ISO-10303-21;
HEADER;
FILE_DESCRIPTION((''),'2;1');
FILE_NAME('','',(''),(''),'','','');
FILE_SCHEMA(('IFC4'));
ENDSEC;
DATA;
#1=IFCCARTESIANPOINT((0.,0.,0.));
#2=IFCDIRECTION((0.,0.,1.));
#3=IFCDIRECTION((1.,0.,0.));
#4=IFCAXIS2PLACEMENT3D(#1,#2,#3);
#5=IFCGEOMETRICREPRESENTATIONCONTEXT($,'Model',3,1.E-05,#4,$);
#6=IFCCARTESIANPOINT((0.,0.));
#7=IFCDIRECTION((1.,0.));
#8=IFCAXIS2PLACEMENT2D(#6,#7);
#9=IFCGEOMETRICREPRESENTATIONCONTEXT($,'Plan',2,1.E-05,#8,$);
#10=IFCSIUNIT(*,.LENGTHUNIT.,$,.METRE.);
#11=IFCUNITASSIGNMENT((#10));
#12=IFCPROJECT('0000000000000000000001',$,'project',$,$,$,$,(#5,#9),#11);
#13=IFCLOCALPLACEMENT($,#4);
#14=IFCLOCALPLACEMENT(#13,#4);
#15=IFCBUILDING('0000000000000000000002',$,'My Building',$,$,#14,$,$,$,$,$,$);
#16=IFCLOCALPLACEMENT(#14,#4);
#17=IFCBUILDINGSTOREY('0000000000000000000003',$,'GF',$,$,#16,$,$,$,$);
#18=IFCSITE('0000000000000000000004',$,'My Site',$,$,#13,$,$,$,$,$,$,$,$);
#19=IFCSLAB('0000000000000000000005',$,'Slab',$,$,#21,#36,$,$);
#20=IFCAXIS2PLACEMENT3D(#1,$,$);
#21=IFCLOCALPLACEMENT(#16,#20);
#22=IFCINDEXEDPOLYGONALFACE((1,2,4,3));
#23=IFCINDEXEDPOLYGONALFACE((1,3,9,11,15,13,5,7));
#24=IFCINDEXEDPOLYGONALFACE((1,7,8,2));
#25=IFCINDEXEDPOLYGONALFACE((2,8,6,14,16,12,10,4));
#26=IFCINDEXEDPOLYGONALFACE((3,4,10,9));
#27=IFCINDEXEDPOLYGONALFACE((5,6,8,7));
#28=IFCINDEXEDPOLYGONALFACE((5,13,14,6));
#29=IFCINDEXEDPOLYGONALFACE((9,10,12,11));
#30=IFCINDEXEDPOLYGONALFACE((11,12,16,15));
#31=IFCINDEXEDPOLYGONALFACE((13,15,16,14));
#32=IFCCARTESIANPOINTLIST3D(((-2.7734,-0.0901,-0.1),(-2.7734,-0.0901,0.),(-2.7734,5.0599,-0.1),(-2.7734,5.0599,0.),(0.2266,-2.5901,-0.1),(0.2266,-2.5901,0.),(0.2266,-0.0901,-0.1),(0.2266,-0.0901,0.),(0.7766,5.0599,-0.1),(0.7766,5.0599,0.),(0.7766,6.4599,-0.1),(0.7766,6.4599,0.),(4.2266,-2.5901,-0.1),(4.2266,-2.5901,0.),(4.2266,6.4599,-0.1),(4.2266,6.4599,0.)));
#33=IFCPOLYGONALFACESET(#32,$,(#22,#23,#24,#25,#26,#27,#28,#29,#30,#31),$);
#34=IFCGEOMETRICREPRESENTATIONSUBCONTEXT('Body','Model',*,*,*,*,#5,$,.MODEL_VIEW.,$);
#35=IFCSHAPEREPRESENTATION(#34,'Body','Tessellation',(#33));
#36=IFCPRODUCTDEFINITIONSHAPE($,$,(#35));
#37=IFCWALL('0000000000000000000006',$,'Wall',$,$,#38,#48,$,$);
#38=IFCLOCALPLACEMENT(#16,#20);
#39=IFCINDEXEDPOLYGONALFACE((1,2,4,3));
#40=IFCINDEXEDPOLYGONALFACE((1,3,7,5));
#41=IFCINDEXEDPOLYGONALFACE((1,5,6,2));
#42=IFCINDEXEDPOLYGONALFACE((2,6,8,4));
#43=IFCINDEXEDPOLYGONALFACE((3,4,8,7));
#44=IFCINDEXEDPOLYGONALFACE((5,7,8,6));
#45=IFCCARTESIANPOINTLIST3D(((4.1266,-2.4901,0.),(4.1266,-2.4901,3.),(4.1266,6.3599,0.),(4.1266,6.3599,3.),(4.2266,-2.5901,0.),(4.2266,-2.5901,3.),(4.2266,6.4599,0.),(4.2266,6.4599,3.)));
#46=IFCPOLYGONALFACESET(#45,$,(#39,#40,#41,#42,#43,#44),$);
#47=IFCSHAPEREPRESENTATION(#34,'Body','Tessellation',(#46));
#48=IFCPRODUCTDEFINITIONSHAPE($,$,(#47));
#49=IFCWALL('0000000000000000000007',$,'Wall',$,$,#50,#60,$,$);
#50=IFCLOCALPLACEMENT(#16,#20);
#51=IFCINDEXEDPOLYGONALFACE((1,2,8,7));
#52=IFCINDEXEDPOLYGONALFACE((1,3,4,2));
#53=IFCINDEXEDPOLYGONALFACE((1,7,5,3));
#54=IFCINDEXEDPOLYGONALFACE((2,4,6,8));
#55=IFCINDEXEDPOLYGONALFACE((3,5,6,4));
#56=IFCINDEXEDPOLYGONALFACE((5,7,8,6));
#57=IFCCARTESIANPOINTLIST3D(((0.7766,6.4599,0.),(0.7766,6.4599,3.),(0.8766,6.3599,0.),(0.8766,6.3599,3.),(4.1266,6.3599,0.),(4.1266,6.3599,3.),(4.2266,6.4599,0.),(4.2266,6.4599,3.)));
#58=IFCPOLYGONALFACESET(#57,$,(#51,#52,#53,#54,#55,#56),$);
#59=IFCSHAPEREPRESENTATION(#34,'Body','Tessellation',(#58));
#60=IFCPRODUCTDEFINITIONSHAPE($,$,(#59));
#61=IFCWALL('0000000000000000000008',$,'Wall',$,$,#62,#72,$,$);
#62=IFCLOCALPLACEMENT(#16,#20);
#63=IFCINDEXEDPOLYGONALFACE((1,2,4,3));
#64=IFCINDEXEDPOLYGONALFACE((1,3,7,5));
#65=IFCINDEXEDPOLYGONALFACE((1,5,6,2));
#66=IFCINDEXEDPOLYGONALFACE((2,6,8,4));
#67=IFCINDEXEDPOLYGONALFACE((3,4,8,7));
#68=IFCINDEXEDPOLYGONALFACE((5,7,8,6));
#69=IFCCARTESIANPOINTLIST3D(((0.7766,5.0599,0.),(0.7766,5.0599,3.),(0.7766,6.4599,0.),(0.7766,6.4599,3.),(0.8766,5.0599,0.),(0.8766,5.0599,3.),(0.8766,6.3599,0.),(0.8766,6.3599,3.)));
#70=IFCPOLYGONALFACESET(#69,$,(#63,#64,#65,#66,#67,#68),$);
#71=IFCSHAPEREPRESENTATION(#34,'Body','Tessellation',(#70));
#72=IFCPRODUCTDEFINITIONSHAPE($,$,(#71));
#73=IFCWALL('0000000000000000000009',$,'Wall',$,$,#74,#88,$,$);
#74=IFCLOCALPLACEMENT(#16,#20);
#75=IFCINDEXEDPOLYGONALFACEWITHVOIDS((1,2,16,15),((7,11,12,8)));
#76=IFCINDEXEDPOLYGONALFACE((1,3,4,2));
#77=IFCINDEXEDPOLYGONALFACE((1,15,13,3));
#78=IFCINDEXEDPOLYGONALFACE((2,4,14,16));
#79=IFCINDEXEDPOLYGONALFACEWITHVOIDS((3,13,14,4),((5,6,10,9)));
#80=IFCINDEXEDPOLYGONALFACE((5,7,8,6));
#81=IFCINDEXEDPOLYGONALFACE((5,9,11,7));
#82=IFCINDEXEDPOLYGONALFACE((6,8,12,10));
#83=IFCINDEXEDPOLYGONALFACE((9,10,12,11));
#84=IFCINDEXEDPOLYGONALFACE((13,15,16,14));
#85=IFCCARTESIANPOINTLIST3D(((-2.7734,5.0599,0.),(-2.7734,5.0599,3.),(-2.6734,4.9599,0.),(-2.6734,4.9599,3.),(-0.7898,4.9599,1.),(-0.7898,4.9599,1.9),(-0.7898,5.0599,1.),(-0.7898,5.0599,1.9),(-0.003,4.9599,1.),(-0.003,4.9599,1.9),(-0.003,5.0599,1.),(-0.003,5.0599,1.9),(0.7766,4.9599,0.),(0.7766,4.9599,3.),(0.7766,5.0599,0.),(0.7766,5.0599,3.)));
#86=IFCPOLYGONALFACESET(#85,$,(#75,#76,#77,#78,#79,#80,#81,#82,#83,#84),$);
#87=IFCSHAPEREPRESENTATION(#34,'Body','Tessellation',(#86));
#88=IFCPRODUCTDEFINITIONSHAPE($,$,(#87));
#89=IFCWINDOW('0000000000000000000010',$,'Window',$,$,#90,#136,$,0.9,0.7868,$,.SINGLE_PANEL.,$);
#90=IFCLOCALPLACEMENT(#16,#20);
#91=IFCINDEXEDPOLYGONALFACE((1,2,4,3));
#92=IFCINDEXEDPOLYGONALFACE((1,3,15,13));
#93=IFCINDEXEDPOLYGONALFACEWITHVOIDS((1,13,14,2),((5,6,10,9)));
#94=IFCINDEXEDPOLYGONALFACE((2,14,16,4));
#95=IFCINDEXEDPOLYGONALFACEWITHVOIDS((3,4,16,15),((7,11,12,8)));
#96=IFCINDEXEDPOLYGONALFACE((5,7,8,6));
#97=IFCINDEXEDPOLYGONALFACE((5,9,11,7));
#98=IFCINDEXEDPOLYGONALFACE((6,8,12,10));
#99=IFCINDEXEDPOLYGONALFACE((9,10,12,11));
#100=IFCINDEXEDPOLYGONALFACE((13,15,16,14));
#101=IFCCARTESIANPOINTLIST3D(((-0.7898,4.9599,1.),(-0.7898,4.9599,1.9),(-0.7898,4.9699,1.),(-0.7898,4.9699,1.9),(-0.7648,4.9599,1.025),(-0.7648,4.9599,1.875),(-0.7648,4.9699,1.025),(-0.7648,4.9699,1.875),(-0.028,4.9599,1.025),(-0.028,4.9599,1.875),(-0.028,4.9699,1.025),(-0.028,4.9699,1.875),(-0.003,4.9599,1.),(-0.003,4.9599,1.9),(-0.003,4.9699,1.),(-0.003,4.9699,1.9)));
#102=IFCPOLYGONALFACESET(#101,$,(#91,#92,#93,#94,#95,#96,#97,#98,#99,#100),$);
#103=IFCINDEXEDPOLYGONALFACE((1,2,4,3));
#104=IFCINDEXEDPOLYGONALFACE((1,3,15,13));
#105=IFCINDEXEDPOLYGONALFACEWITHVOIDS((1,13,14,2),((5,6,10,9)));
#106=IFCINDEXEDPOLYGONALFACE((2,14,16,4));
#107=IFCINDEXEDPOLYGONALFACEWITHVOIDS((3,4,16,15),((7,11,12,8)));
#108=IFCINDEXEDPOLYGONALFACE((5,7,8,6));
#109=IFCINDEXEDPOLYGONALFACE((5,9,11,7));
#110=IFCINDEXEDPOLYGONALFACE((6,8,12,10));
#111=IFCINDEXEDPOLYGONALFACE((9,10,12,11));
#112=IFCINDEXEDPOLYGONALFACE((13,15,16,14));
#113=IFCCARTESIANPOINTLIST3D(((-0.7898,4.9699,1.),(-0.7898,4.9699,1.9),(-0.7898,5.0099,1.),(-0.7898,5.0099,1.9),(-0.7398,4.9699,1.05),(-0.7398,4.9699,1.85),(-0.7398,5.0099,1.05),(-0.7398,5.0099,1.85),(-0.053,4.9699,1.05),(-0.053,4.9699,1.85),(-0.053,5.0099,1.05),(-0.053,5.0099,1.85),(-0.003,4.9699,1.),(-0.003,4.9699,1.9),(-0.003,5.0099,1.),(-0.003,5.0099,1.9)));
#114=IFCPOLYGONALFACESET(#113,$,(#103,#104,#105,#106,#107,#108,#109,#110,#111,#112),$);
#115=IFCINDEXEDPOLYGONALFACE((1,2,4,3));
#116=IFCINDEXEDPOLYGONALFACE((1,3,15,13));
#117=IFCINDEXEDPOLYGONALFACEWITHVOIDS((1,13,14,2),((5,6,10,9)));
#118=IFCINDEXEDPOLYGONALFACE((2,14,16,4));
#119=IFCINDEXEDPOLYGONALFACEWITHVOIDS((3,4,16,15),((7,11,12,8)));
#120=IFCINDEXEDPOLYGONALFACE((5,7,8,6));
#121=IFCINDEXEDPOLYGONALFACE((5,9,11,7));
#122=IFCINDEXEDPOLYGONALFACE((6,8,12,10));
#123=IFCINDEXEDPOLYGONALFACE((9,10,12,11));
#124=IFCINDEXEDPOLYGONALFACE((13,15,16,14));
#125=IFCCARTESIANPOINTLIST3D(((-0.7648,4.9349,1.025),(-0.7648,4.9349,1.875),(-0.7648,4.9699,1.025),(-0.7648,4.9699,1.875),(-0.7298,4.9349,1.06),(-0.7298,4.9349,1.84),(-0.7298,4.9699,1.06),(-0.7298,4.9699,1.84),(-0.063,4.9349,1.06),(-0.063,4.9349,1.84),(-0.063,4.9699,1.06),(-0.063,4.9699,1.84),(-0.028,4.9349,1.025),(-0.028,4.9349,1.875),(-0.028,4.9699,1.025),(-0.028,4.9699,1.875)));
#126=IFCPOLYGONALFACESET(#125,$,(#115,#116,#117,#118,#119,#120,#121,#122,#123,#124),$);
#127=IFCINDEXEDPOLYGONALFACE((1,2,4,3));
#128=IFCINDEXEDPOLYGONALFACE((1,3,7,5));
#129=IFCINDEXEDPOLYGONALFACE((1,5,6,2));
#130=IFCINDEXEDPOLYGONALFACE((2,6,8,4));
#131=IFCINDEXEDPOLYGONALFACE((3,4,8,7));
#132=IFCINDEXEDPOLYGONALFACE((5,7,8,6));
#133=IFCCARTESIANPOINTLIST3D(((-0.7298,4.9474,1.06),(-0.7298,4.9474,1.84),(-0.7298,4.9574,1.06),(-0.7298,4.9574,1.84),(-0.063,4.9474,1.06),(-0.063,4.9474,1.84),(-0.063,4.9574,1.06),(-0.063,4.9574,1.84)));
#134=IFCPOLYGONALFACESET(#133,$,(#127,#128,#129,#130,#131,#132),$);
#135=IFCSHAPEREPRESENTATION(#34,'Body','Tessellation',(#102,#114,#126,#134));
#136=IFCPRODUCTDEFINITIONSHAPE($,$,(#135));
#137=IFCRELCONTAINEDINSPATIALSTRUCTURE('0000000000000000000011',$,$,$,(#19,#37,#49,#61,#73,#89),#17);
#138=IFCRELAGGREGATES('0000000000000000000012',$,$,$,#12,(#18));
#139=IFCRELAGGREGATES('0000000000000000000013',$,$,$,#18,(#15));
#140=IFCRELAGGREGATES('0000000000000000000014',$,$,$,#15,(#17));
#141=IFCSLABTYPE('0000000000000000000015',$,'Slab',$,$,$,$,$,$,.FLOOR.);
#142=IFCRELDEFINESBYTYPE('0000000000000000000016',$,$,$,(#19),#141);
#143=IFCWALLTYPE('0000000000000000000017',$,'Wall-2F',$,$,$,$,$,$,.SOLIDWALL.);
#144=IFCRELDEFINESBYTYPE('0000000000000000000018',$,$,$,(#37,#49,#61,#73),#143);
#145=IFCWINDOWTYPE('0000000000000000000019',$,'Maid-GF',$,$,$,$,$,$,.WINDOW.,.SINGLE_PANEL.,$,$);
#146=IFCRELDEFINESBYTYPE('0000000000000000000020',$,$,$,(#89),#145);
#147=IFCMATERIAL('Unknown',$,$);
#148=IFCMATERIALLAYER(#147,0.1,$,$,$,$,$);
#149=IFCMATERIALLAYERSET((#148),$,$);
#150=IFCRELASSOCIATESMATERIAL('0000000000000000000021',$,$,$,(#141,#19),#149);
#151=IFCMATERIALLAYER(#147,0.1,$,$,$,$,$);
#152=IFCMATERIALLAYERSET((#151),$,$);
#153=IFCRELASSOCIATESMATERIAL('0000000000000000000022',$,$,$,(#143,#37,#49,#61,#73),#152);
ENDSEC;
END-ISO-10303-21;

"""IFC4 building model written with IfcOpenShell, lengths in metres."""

from ifc_helpers import new_model, entity, si_unit, frame, origin_with_axes, origin_2d_with_axis, place, context, subcontext, project, spatial, line, indexed_curve, outline, extrude, shape, source, transform, mapped, material, layer, layer_set, layer_usage, type_object, type_shapes, element, fill, save


model = new_model("IFC4")

# Units and contexts
model_context = context("Model", 3, precision=1e-05, world=origin_with_axes())
plan_context = context("Plan", 2, precision=1e-05, world=origin_2d_with_axis())
body_context_1 = subcontext(model_context, "Body", "Model", "MODEL_VIEW")
body_context_2 = subcontext(plan_context, "Body", "Plan", "PLAN_VIEW")
ifc_project = project(units=[si_unit("LENGTHUNIT", "METRE")], contexts=[model_context, plan_context])

# Site, building, storey
site_placement = place(None, origin_with_axes())
site = spatial("IfcSite", under=ifc_project, at=site_placement, Name="My Site")
building_placement = place(site_placement, origin_with_axes())
building = spatial("IfcBuilding", under=site, at=building_placement, Name="My Building")
storey_placement = place(building_placement, origin_with_axes())
storey = spatial("IfcBuildingStorey", under=building, at=storey_placement, Name="GF")

# Slab
ifc_material_1 = material(Name="Unknown")
ifc_layer_1 = layer(ifc_material_1, 0.1)
ifc_layer_set_1 = layer_set([ifc_layer_1])
ifc_layer_usage_1 = layer_usage(ifc_layer_set_1, "AXIS3", "POSITIVE", -0.1)
slab_type_1 = type_object("IfcSlabType", Name="Slab", PredefinedType="FLOOR", material=ifc_layer_set_1)
slab_1_placement = place(storey_placement, frame((4.2266, -2.5901, 0.0), z_axis=(0.0, 0.0, 1.0), x_axis=(1.0, 0.0, 0.0)))
element("IfcSlab", 1, at=slab_1_placement, inside=storey, type_object=slab_type_1, material=ifc_layer_usage_1, Name="Slab", context=body_context_1, shape_type="SweptSolid", body=[
    extrude(outline(indexed_curve([(0.0, 0.0), (0.0, 9.05), (-3.45, 9.05), (-3.45, 7.65), (-7.0, 7.65), (-7.0, 2.5), (-4.0, 2.5), (-4.0, 0.0), (0.0, 0.0)])), frame((0.0, 0.0, -0.1), z_axis=(0.0, 0.0, 1.0), x_axis=(1.0, 0.0, 0.0)), (0.0, 0.0, 1.0), 0.1),
])

# Shared definitions
ifc_layer_2 = layer(ifc_material_1, 0.1)
ifc_layer_set_2 = layer_set([ifc_layer_2])
wall_type = type_object("IfcWallType", Name="Wall-2F", PredefinedType="SOLIDWALL", material=ifc_layer_set_2)

# Walls
ifc_layer_usage_2 = layer_usage(ifc_layer_set_2, "AXIS2", "POSITIVE", 0.0)
wall_1_placement = place(storey_placement, frame((4.2266, -2.5901, 0.0), z_axis=(0.0, 0.0, 1.0), x_axis=(0.0, 1.0, 0.0)))
element("IfcWall", 2, at=wall_1_placement, inside=storey, type_object=wall_type, material=ifc_layer_usage_2, Name="Wall", context=body_context_1, shape_type="SweptSolid", body=[
    extrude(outline(indexed_curve([(0.0, 0.0), (0.1, 0.1), (8.95, 0.1), (9.05, 0.0)], segments=[line(1, 2, 3, 4, 1)])), origin_with_axes(), (0.0, 0.0, 1.0), 3.0),
])
ifc_layer_usage_3 = layer_usage(ifc_layer_set_2, "AXIS2", "POSITIVE", 0.0)
wall_2_placement = place(storey_placement, frame((4.2266, 6.4599, 0.0), z_axis=(0.0, 0.0, 1.0), x_axis=(-1.0, 0.0, 0.0)))
element("IfcWall", 3, at=wall_2_placement, inside=storey, type_object=wall_type, material=ifc_layer_usage_3, Name="Wall", context=body_context_1, shape_type="SweptSolid", body=[
    extrude(outline(indexed_curve([(0.0, 0.0), (0.1, 0.1), (3.35, 0.1), (3.45, 0.0)], segments=[line(1, 2, 3, 4, 1)])), origin_with_axes(), (0.0, 0.0, 1.0), 3.0),
])
ifc_layer_usage_4 = layer_usage(ifc_layer_set_2, "AXIS2", "POSITIVE", 0.0)
wall_3_placement = place(storey_placement, frame((0.7766, 6.4599, 0.0), z_axis=(0.0, 0.0, 1.0), x_axis=(0.0, -1.0, 0.0)))
element("IfcWall", 4, at=wall_3_placement, inside=storey, type_object=wall_type, material=ifc_layer_usage_4, Name="Wall", context=body_context_1, shape_type="SweptSolid", body=[
    extrude(outline(indexed_curve([(0.0, 0.0), (0.1, 0.1), (1.4, 0.1), (1.4, 0.0)], segments=[line(1, 2, 3, 4, 1)])), origin_with_axes(), (0.0, 0.0, 1.0), 3.0),
])

# Wall, opening, window
ifc_layer_usage_5 = layer_usage(ifc_layer_set_2, "AXIS2", "POSITIVE", 0.0)
wall_4_placement = place(storey_placement, frame((0.7766, 5.0599, 0.0), z_axis=(0.0, 0.0, 1.0), x_axis=(-1.0, 0.0, 0.0)))
wall_4 = element("IfcWall", 5, at=wall_4_placement, inside=storey, type_object=wall_type, material=ifc_layer_usage_5, Name="Wall", context=body_context_1, shape_type="SweptSolid", body=[
    extrude(outline(indexed_curve([(0.0, 0.0), (0.0, 0.1), (3.45, 0.1), (3.55, 0.0)], segments=[line(1, 2, 3, 4, 1)])), origin_with_axes(), (0.0, 0.0, 1.0), 3.0),
])
shared_shape_1 = source(origin_with_axes(), body_context_1, "Body", "SweptSolid", [
    extrude(outline(indexed_curve([(0.0, 0.0), (0.7868, 0.0), (0.7868, 0.9), (0.0, 0.9)], segments=[line(1, 2, 3, 4, 1)])), frame((0.0, -0.6, 0.0), z_axis=(0.0, -1.0, 0.0), x_axis=(1.0, 0.0, 0.0)), (0.0, 0.0, -1.0), 1.2),
])
opening_1_placement = place(wall_4_placement, frame((0.7796, 0.0, 1.0), z_axis=(0.0, 0.0, 1.0), x_axis=(1.0, 0.0, 0.0)))
opening_1 = element("IfcOpeningElement", 6, at=opening_1_placement, cuts=wall_4, PredefinedType="OPENING", context=body_context_1, shape_type="MappedRepresentation", body=[
    mapped(shared_shape_1, transform((0.0, 0.0, 0.0), x_axis=(1.0, 0.0, 0.0), y_axis=(0.0, 1.0, 0.0), z_axis=(0.0, 0.0, 1.0), scale=1.0)),
])
window_type_1 = type_object("IfcWindowType", Name="Maid-GF", PartitioningType="SINGLE_PANEL", PredefinedType="WINDOW")
shared_shape_2 = source(origin_with_axes(), body_context_1, "Body", "SweptSolid", [
    extrude(outline(indexed_curve([(0.0, 0.0), (0.7868, 0.0), (0.7868, 0.9), (0.0, 0.9)], segments=[line(1, 2, 3, 4, 1)]), holes=[indexed_curve([(0.025, 0.025), (0.7618, 0.025), (0.7618, 0.875), (0.025, 0.875)], segments=[line(1, 2, 3, 4, 1)])]), frame((0.0, 0.09, 0.0), z_axis=(0.0, -1.0, 0.0), x_axis=(1.0, 0.0, 0.0)), (0.0, 0.0, -1.0), 0.01),
    extrude(outline(indexed_curve([(0.0, 0.0), (0.7868, 0.0), (0.7868, 0.9), (0.0, 0.9)], segments=[line(1, 2, 3, 4, 1)]), holes=[indexed_curve([(0.05, 0.05), (0.7368, 0.05), (0.7368, 0.85), (0.05, 0.85)], segments=[line(1, 2, 3, 4, 1)])]), frame((0.0, 0.05, 0.0), z_axis=(0.0, -1.0, 0.0), x_axis=(1.0, 0.0, 0.0)), (0.0, 0.0, -1.0), 0.04),
    extrude(outline(indexed_curve([(0.0, 0.0), (0.7368, 0.0), (0.7368, 0.85), (0.0, 0.85)], segments=[line(1, 2, 3, 4, 1)]), holes=[indexed_curve([(0.035, 0.035), (0.7018, 0.035), (0.7018, 0.815), (0.035, 0.815)], segments=[line(1, 2, 3, 4, 1)])]), frame((0.025, 0.09, 0.025), z_axis=(0.0, -1.0, 0.0), x_axis=(1.0, 0.0, 0.0)), (0.0, 0.0, -1.0), 0.035),
    extrude(outline(indexed_curve([(0.035, 0.035), (0.7018, 0.035), (0.7018, 0.815), (0.035, 0.815)], segments=[line(1, 2, 3, 4, 1)])), frame((0.025, 0.1025, 0.025), z_axis=(0.0, -1.0, 0.0), x_axis=(1.0, 0.0, 0.0)), (0.0, 0.0, -1.0), 0.01),
])
shared_shape_3 = source(origin_with_axes(), body_context_2, "Body", "Curve2D", [
    entity("IfcIndexedPolyCurve", entity("IfcCartesianPointList2D", [[0.05, 0.05], [0.7368, 0.05]])),
    entity("IfcIndexedPolyCurve", entity("IfcCartesianPointList2D", [[0.0, 0.1], [0.025, 0.1], [0.025, 0.09], [0.05, 0.09], [0.05, 0.05], [0.0, 0.05]]), [entity("IfcLineIndex", [1, 2, 3, 4, 5, 6, 1])]),
    entity("IfcIndexedPolyCurve", entity("IfcCartesianPointList2D", [[0.7868, 0.1], [0.7618, 0.1], [0.7618, 0.09], [0.7368, 0.09], [0.7368, 0.05], [0.7868, 0.05]]), [entity("IfcLineIndex", [1, 2, 3, 4, 5, 6, 1])]),
    entity("IfcIndexedPolyCurve", entity("IfcCartesianPointList2D", [[0.025, 0.09], [0.06, 0.09], [0.06, 0.125], [0.025, 0.125]]), [entity("IfcLineIndex", [1, 2, 3, 4, 1])]),
    entity("IfcIndexedPolyCurve", entity("IfcCartesianPointList2D", [[0.7618, 0.09], [0.7268, 0.09], [0.7268, 0.125], [0.7618, 0.125]]), [entity("IfcLineIndex", [1, 2, 3, 4, 1])]),
    entity("IfcIndexedPolyCurve", entity("IfcCartesianPointList2D", [[0.06, 0.09], [0.7268, 0.09]])),
    entity("IfcIndexedPolyCurve", entity("IfcCartesianPointList2D", [[0.06, 0.125], [0.7268, 0.125]])),
    entity("IfcIndexedPolyCurve", entity("IfcCartesianPointList2D", [[0.06, 0.1075], [0.7268, 0.1075]])),
])
type_shapes(window_type_1, [shared_shape_2, shared_shape_3])
window_1_placement = place(opening_1_placement, frame((0.0, 0.0, 0.0), z_axis=(0.0, 0.0, 1.0), x_axis=(1.0, 0.0, 0.0)))
window_1 = element("IfcWindow", 7, at=window_1_placement, inside=storey, type_object=window_type_1, Name="Window", OverallHeight=0.9, OverallWidth=0.7868, PartitioningType="SINGLE_PANEL", shapes=[
    shape(body_context_1, "Body", "MappedRepresentation", [mapped(shared_shape_2, transform((0.0, 0.0, 0.0), x_axis=(1.0, 0.0, 0.0), y_axis=(0.0, 1.0, 0.0), z_axis=(0.0, 0.0, 1.0), scale=1.0))]),
    shape(body_context_2, "Body", "MappedRepresentation", [mapped(shared_shape_3, transform((0.0, 0.0, 0.0), x_axis=(1.0, 0.0, 0.0), y_axis=(0.0, 1.0, 0.0), z_axis=(0.0, 0.0, 1.0), scale=1.0))]),
])
fill(opening_1, window_1)

save(model, "model.ifc")
